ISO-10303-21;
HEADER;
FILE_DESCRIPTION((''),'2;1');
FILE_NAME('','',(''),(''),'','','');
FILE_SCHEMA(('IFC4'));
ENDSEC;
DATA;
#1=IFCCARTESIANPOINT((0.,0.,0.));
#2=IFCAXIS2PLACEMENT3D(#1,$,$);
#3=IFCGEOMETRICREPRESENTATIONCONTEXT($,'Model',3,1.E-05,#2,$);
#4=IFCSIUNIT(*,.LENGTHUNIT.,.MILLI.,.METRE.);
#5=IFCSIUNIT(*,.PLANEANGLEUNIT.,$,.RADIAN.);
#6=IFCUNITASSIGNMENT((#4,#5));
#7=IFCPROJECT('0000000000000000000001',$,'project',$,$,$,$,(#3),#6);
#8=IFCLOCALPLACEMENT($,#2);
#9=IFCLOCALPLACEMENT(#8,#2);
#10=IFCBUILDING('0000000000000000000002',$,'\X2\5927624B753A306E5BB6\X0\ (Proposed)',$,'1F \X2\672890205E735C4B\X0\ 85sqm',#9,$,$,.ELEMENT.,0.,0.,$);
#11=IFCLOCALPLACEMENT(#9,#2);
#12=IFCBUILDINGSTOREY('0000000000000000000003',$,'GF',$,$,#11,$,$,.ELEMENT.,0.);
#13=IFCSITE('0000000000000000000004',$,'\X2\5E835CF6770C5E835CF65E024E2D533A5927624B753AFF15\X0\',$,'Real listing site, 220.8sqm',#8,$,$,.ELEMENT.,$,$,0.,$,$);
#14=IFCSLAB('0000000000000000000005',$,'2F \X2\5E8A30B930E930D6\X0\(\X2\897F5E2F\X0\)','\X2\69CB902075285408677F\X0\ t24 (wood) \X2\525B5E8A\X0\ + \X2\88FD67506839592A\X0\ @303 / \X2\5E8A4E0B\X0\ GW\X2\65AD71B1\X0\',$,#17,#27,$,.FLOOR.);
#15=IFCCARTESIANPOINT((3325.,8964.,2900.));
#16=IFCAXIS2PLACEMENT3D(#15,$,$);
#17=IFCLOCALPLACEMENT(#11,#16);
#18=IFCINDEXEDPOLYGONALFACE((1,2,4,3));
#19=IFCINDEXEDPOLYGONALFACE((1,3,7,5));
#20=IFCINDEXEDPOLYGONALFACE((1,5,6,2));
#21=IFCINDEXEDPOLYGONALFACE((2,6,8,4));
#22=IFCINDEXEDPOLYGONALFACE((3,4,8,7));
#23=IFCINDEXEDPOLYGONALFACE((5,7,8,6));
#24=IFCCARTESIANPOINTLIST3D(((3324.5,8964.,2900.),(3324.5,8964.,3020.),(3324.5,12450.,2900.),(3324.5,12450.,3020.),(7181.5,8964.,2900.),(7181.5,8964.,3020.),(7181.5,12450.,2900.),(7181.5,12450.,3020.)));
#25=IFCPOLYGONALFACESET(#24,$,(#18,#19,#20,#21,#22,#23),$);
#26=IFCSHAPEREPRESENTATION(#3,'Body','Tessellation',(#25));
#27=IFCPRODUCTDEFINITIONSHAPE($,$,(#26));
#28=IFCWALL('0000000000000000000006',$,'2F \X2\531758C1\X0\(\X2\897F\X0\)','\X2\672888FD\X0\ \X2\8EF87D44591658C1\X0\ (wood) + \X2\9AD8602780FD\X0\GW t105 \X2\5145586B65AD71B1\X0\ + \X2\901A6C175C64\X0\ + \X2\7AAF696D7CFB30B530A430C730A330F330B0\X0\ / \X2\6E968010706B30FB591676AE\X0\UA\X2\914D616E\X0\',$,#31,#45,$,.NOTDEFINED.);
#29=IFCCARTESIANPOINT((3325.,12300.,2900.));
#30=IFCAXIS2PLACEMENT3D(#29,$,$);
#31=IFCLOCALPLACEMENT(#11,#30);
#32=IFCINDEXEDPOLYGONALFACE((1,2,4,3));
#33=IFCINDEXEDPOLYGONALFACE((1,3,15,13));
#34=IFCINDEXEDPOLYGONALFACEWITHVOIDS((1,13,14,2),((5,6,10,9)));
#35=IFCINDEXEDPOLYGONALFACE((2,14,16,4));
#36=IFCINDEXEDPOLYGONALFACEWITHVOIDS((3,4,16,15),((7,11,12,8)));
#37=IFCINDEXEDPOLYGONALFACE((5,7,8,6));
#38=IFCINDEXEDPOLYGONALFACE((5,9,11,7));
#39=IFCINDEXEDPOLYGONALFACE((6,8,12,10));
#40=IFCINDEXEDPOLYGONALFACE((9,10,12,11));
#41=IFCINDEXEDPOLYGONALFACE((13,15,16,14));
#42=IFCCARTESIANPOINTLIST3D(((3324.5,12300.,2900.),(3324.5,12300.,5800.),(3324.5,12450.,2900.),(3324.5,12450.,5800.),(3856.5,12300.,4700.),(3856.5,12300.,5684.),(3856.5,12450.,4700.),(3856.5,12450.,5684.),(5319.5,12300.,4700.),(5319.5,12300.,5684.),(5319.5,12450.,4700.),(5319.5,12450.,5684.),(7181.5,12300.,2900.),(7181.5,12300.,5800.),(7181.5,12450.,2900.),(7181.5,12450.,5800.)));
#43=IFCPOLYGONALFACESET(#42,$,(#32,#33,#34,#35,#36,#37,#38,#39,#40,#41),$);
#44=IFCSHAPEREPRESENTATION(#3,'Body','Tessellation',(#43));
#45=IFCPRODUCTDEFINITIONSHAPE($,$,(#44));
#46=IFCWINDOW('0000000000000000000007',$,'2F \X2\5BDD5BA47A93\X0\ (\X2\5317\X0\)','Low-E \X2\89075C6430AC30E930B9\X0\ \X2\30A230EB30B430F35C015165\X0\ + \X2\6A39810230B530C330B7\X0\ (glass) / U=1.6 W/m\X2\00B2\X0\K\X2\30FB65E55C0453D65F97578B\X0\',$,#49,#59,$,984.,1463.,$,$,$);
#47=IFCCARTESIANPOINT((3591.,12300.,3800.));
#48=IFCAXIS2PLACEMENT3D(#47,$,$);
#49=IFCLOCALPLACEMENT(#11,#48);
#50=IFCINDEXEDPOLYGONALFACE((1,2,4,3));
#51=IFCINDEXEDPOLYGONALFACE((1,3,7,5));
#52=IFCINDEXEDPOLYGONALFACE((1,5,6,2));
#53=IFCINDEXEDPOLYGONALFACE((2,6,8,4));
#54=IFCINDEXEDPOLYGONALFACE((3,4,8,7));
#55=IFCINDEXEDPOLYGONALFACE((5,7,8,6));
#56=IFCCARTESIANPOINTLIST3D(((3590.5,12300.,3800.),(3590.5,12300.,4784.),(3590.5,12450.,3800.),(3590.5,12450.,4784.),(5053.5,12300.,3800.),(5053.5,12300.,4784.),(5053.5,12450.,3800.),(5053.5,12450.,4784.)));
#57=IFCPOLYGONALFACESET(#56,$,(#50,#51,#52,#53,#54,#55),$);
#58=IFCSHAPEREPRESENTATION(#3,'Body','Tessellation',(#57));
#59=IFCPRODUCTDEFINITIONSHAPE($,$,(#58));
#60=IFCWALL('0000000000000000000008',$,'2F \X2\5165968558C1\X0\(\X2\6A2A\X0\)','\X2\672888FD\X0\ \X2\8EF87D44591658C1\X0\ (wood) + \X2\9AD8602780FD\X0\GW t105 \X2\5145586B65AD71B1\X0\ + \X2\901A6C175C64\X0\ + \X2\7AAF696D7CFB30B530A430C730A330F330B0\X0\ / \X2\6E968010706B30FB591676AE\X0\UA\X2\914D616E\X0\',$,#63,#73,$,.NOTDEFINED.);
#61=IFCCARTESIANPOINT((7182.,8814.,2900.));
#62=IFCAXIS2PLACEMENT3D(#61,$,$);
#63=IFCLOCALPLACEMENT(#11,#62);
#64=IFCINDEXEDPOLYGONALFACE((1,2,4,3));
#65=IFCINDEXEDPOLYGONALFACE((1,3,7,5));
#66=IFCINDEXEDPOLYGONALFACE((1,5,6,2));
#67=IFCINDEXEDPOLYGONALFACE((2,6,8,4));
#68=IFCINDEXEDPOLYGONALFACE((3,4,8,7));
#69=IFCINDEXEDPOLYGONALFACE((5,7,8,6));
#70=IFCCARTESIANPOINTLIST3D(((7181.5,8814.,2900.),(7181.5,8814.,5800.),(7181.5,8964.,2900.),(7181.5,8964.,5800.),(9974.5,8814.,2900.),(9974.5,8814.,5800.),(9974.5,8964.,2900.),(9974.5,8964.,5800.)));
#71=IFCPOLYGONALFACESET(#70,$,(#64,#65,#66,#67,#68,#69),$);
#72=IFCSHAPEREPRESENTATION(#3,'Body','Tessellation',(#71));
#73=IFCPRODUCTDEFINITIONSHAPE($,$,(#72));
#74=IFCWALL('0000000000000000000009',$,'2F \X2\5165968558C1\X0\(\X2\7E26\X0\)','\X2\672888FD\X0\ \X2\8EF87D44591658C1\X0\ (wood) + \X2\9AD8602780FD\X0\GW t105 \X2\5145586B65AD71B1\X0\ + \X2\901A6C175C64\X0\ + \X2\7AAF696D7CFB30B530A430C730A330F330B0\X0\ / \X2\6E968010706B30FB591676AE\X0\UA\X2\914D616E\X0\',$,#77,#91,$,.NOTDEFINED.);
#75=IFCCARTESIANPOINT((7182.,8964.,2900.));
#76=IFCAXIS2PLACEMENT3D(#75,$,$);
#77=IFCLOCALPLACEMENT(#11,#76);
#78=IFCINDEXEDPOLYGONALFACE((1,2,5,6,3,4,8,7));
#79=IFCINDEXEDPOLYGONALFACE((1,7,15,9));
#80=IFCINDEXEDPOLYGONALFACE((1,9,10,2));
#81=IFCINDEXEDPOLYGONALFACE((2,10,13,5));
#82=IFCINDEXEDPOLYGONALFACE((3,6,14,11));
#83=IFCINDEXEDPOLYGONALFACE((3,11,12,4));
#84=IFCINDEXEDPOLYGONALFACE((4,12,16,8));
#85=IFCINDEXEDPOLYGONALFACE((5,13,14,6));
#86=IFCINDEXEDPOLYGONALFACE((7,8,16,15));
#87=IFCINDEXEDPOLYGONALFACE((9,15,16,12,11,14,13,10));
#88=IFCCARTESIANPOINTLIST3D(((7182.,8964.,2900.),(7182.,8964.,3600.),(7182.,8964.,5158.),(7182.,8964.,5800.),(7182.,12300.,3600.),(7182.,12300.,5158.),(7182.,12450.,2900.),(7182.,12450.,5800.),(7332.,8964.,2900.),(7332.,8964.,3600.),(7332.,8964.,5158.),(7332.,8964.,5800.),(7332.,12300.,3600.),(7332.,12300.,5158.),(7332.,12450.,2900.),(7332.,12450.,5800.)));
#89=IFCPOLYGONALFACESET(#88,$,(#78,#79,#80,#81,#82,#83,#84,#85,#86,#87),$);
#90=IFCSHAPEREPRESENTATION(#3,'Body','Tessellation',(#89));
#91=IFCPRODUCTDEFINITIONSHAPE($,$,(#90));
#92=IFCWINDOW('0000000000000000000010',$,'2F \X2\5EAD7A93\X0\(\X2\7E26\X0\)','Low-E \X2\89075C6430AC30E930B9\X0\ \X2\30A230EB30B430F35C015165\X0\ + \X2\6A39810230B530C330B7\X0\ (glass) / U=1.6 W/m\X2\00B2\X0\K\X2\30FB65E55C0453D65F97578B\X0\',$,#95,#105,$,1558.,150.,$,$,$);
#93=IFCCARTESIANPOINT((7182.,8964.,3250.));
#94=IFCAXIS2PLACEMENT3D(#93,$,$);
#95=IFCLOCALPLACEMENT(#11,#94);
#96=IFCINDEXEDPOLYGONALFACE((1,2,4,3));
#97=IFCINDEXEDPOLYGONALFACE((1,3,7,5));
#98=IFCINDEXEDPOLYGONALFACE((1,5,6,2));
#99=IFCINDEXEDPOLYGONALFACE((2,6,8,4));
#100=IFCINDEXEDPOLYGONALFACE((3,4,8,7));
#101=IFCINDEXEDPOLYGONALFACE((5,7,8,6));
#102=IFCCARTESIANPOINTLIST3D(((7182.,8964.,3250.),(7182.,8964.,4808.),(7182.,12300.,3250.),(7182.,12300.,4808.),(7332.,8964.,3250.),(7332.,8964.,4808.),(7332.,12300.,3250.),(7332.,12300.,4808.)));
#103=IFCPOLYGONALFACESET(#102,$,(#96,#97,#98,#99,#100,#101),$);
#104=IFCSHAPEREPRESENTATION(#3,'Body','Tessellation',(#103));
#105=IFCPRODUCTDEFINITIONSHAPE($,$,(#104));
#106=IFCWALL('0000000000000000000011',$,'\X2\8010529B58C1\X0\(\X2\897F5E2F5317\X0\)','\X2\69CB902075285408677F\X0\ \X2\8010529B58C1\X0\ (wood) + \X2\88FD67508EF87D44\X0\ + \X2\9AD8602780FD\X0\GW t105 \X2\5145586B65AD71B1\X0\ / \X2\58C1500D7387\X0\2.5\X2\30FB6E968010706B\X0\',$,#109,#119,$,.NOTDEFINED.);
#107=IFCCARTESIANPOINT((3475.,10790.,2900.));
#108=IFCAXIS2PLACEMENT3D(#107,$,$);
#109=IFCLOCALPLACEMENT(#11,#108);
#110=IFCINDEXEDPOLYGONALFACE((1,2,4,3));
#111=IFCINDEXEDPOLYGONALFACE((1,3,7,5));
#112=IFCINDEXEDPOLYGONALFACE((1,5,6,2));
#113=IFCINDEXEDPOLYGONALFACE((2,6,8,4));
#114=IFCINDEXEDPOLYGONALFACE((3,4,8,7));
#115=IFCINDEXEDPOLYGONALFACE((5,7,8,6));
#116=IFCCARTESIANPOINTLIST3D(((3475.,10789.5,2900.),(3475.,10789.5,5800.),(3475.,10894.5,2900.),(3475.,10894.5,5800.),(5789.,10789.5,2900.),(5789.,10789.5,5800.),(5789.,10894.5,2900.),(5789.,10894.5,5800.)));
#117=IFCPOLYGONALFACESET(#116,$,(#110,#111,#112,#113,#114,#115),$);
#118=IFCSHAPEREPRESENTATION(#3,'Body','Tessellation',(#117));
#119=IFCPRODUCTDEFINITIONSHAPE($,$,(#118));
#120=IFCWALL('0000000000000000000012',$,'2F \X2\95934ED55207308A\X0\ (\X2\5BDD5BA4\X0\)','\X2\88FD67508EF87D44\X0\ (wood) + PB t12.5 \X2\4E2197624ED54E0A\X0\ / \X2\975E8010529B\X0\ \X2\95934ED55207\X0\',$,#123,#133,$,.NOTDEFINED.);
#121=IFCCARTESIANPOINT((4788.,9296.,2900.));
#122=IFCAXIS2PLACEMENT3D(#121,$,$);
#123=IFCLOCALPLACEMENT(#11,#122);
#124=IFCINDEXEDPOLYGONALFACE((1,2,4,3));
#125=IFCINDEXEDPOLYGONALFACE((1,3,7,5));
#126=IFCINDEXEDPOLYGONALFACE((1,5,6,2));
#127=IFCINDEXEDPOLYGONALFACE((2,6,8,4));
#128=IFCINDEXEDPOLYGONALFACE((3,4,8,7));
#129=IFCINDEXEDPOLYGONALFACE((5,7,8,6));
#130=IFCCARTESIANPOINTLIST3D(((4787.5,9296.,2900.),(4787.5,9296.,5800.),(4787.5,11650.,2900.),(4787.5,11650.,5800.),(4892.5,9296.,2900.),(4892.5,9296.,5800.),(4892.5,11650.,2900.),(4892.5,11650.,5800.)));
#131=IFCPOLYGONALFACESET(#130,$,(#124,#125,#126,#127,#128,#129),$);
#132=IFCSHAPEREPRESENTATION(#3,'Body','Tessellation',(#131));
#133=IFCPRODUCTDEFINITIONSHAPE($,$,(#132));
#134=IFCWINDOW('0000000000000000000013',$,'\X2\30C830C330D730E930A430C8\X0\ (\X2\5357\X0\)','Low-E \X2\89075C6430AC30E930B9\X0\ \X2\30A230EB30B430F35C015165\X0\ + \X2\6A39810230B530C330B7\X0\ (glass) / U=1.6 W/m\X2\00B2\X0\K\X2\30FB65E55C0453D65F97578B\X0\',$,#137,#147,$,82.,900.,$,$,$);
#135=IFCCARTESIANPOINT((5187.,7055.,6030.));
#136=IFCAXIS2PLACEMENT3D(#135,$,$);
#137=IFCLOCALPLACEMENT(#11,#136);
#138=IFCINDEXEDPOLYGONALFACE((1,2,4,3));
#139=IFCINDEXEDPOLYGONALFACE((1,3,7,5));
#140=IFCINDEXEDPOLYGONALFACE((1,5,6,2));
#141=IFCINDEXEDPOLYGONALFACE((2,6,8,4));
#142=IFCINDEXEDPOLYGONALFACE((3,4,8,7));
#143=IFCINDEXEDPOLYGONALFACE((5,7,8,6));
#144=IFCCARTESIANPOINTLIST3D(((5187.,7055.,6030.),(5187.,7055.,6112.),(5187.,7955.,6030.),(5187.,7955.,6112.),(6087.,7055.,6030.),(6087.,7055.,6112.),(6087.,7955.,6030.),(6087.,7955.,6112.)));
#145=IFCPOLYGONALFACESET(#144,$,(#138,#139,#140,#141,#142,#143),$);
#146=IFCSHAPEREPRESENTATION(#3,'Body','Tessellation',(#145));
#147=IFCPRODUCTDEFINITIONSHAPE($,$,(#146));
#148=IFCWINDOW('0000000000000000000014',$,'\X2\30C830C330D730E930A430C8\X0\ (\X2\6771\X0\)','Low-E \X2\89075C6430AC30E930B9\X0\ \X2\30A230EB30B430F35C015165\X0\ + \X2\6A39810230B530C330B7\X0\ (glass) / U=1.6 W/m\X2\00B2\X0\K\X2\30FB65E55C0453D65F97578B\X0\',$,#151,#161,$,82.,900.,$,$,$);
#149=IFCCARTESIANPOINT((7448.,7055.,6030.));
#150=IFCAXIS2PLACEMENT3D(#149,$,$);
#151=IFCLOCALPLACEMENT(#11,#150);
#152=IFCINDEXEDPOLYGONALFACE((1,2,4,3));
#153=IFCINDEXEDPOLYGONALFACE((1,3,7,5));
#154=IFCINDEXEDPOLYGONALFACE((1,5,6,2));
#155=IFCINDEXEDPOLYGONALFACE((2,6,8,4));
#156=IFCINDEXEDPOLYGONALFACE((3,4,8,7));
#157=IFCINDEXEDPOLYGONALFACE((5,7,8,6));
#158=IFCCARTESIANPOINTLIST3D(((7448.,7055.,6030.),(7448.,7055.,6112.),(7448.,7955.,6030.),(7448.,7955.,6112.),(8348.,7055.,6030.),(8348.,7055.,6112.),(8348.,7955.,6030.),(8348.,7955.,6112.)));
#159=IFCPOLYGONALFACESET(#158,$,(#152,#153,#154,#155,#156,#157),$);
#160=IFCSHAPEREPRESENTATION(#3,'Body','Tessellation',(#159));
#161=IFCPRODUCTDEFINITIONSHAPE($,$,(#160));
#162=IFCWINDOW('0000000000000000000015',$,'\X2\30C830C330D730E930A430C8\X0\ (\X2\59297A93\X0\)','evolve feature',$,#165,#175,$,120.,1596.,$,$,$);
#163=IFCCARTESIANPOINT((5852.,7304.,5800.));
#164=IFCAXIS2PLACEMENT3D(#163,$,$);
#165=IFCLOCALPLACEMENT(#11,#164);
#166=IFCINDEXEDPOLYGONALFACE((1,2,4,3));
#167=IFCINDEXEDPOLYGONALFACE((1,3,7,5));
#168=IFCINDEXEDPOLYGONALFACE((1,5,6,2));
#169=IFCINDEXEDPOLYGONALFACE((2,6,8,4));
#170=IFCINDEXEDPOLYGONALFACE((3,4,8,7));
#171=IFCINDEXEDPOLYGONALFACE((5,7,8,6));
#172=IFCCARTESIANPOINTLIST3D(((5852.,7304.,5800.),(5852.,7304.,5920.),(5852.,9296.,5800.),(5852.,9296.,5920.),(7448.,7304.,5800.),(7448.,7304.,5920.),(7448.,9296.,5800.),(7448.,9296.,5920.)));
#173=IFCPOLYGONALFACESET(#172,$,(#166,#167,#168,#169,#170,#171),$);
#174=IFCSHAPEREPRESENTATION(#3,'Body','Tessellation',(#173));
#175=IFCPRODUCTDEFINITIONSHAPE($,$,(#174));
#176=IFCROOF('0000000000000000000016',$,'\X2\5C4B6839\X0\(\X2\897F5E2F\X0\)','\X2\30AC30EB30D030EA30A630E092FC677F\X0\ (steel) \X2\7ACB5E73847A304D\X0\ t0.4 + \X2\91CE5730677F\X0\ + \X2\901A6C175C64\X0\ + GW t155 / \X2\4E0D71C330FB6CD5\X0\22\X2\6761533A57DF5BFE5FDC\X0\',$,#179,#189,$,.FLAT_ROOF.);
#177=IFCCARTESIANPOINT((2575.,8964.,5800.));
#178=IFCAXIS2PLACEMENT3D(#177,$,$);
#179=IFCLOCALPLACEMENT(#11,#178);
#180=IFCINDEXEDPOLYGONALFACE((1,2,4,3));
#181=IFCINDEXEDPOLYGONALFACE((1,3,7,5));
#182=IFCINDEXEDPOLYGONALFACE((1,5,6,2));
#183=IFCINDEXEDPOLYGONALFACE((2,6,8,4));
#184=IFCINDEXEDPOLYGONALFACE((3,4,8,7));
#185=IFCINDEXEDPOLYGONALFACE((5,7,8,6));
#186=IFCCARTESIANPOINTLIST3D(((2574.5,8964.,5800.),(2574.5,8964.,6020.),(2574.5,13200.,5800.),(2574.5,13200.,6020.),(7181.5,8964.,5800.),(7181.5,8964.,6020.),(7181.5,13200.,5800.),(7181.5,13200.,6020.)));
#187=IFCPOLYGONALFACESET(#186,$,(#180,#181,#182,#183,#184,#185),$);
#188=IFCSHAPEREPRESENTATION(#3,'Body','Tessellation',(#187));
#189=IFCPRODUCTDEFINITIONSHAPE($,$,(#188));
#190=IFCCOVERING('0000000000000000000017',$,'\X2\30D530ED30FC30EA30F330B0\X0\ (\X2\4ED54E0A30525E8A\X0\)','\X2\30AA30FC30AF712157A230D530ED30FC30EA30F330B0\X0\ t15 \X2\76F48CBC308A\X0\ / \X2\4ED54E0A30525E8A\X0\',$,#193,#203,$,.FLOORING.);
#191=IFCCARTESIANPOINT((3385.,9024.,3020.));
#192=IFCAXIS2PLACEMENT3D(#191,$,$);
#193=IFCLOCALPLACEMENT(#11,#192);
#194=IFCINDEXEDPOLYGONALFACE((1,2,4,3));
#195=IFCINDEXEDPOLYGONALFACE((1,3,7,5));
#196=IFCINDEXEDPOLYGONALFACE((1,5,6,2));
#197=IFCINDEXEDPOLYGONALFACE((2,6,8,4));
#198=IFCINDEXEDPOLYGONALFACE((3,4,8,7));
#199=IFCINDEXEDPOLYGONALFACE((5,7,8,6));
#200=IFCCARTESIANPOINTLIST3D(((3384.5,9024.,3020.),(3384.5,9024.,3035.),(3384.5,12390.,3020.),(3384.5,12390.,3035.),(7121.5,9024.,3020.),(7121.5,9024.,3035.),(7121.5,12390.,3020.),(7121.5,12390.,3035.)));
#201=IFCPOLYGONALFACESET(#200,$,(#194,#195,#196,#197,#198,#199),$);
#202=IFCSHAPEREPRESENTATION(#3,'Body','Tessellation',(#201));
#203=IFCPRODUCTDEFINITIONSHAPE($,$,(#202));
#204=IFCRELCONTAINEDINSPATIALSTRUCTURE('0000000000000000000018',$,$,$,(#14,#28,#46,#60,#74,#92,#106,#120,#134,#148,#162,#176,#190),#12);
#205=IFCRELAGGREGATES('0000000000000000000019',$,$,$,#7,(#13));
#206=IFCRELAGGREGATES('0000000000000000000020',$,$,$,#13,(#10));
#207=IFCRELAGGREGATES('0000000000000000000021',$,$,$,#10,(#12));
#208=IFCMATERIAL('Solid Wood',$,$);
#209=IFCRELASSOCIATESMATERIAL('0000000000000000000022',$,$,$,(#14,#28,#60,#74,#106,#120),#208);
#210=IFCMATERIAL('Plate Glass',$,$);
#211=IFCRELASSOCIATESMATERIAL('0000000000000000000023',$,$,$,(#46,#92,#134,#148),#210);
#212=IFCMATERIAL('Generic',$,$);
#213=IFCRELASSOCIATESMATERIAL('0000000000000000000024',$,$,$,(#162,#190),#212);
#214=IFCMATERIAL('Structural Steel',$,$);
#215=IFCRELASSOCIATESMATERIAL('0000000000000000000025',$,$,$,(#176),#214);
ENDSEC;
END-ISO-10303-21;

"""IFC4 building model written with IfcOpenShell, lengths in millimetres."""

from ifc_helpers import new_model, si_unit, frame, frame_2d, origin, place, context, project, spatial, rectangle, extrude, material, element, fill, save


model = new_model("IFC4")

# Units and contexts
model_context = context("Model", 3, precision=1e-05, world=origin())
ifc_project = project(units=[si_unit("LENGTHUNIT", "METRE", prefix="MILLI"), si_unit("PLANEANGLEUNIT", "RADIAN")], contexts=[model_context])

# Site, building, storey
site_placement = place(None, origin())
site = spatial("IfcSite", under=ifc_project, at=site_placement, Name="広島県広島市中区大手町５", ObjectType="Real listing site, 220.8sqm", CompositionType="ELEMENT", RefElevation=0.0)
building_placement = place(site_placement, origin())
building = spatial("IfcBuilding", under=site, at=building_placement, Name="大手町の家 (Proposed)", ObjectType="1F 木造平屋 85sqm", CompositionType="ELEMENT", ElevationOfRefHeight=0.0, ElevationOfTerrain=0.0)
storey_placement = place(building_placement, origin())
storey = spatial("IfcBuildingStorey", under=building, at=storey_placement, Name="GF", CompositionType="ELEMENT", Elevation=0.0)

# Slab
ifc_material_1 = material(Name="Solid Wood")
slab_placement = place(storey_placement, frame((3325.0, 8964.0, 2900.0)))
element("IfcSlab", 1, at=slab_placement, inside=storey, material=ifc_material_1, Name="2F 床スラブ(西帯)", Description="構造用合板 t24 (wood) 剛床 + 製材根太 @303 / 床下 GW断熱", PredefinedType="FLOOR", context=model_context, shape_type="SweptSolid", body=[
    extrude(rectangle(XDim=3857.0, YDim=3486.0, at=frame_2d((1928.0, 1743.0))), frame((3325.0, 8964.0, 2900.0)), (0.0, 0.0, 1.0), 120.0),
])

# Wall, opening, window
wall_1_placement = place(storey_placement, frame((3325.0, 12300.0, 2900.0)))
wall_1 = element("IfcWall", 2, at=wall_1_placement, inside=storey, material=ifc_material_1, Name="2F 北壁(西)", Description="木製 軸組外壁 (wood) + 高性能GW t105 充填断熱 + 通気層 + 窯業系サイディング / 準耐火・外皮UA配慮", PredefinedType="NOTDEFINED", context=model_context, shape_type="SweptSolid", body=[
    extrude(rectangle(XDim=3857.0, YDim=150.0, at=frame_2d((1928.0, 75.0))), frame((3325.0, 12300.0, 2900.0)), (0.0, 0.0, 1.0), 2900.0),
])
opening_1_placement = place(storey_placement, frame((3591.0, 12300.0, 3800.0)))
opening_1 = element("IfcOpeningElement", 3, at=opening_1_placement, cuts=wall_1, PredefinedType="NOTDEFINED", context=model_context, shape_type="SweptSolid", body=[
    extrude(rectangle(XDim=1463.0, YDim=150.0, at=frame_2d((731.0, 75.0))), frame((3591.0, 12300.0, 3800.0)), (0.0, 0.0, 1.0), 984.0),
])
ifc_material_2 = material(Name="Plate Glass")
window_1_placement = place(storey_placement, frame((3591.0, 12300.0, 3800.0)))
window_1 = element("IfcWindow", 4, at=window_1_placement, inside=storey, material=ifc_material_2, Name="2F 寝室窓 (北)", Description="Low-E 複層ガラス アルゴン封入 + 樹脂サッシ (glass) / U=1.6 W/m²K・日射取得型", OverallHeight=984.0, OverallWidth=1463.0, context=model_context, shape_type="SweptSolid", body=[
    extrude(rectangle(XDim=1463.0, YDim=150.0, at=frame_2d((731.0, 75.0))), frame((3591.0, 12300.0, 3800.0)), (0.0, 0.0, 1.0), 984.0),
])
fill(opening_1, window_1)

# Wall
wall_2_placement = place(storey_placement, frame((7182.0, 8814.0, 2900.0)))
element("IfcWall", 5, at=wall_2_placement, inside=storey, material=ifc_material_1, Name="2F 入隅壁(横)", Description="木製 軸組外壁 (wood) + 高性能GW t105 充填断熱 + 通気層 + 窯業系サイディング / 準耐火・外皮UA配慮", PredefinedType="NOTDEFINED", context=model_context, shape_type="SweptSolid", body=[
    extrude(rectangle(XDim=2793.0, YDim=150.0, at=frame_2d((1396.0, 75.0))), frame((7182.0, 8814.0, 2900.0)), (0.0, 0.0, 1.0), 2900.0),
])

# Wall, opening, window
wall_3_placement = place(storey_placement, frame((7182.0, 8964.0, 2900.0)))
wall_3 = element("IfcWall", 6, at=wall_3_placement, inside=storey, material=ifc_material_1, Name="2F 入隅壁(縦)", Description="木製 軸組外壁 (wood) + 高性能GW t105 充填断熱 + 通気層 + 窯業系サイディング / 準耐火・外皮UA配慮", PredefinedType="NOTDEFINED", context=model_context, shape_type="SweptSolid", body=[
    extrude(rectangle(XDim=150.0, YDim=3486.0, at=frame_2d((75.0, 1743.0))), frame((7182.0, 8964.0, 2900.0)), (0.0, 0.0, 1.0), 2900.0),
])
opening_2_placement = place(storey_placement, frame((7182.0, 8964.0, 3250.0)))
opening_2 = element("IfcOpeningElement", 7, at=opening_2_placement, cuts=wall_3, PredefinedType="NOTDEFINED", context=model_context, shape_type="SweptSolid", body=[
    extrude(rectangle(XDim=150.0, YDim=3336.0, at=frame_2d((75.0, 1668.0))), frame((7182.0, 8964.0, 3250.0)), (0.0, 0.0, 1.0), 1558.0),
])
window_2_placement = place(storey_placement, frame((7182.0, 8964.0, 3250.0)))
window_2 = element("IfcWindow", 8, at=window_2_placement, inside=storey, material=ifc_material_2, Name="2F 庭窓(縦)", Description="Low-E 複層ガラス アルゴン封入 + 樹脂サッシ (glass) / U=1.6 W/m²K・日射取得型", OverallHeight=1558.0, OverallWidth=150.0, context=model_context, shape_type="SweptSolid", body=[
    extrude(rectangle(XDim=150.0, YDim=3336.0, at=frame_2d((75.0, 1668.0))), frame((7182.0, 8964.0, 3250.0)), (0.0, 0.0, 1.0), 1558.0),
])
fill(opening_2, window_2)

# Walls
wall_4_placement = place(storey_placement, frame((3475.0, 10790.0, 2900.0)))
element("IfcWall", 9, at=wall_4_placement, inside=storey, material=ifc_material_1, Name="耐力壁(西帯北)", Description="構造用合板 耐力壁 (wood) + 製材軸組 + 高性能GW t105 充填断熱 / 壁倍率2.5・準耐火", PredefinedType="NOTDEFINED", context=model_context, shape_type="SweptSolid", body=[
    extrude(rectangle(XDim=2314.0, YDim=105.0, at=frame_2d((1157.0, 52.0))), frame((3475.0, 10790.0, 2900.0)), (0.0, 0.0, 1.0), 2900.0),
])
wall_5_placement = place(storey_placement, frame((4788.0, 9296.0, 2900.0)))
element("IfcWall", 10, at=wall_5_placement, inside=storey, material=ifc_material_1, Name="2F 間仕切り (寝室)", Description="製材軸組 (wood) + PB t12.5 両面仕上 / 非耐力 間仕切", PredefinedType="NOTDEFINED", context=model_context, shape_type="SweptSolid", body=[
    extrude(rectangle(XDim=105.0, YDim=2354.0, at=frame_2d((52.0, 1177.0))), frame((4788.0, 9296.0, 2900.0)), (0.0, 0.0, 1.0), 2900.0),
])

# Windows
window_3_placement = place(storey_placement, frame((5187.0, 7055.0, 6030.0)))
element("IfcWindow", 11, at=window_3_placement, inside=storey, material=ifc_material_2, Name="トップライト (南)", Description="Low-E 複層ガラス アルゴン封入 + 樹脂サッシ (glass) / U=1.6 W/m²K・日射取得型", OverallHeight=82.0, OverallWidth=900.0, context=model_context, shape_type="SweptSolid", body=[
    extrude(rectangle(XDim=900.0, YDim=900.0, at=frame_2d((450.0, 450.0))), frame((5187.0, 7055.0, 6030.0)), (0.0, 0.0, 1.0), 82.0),
])
window_4_placement = place(storey_placement, frame((7448.0, 7055.0, 6030.0)))
element("IfcWindow", 12, at=window_4_placement, inside=storey, material=ifc_material_2, Name="トップライト (東)", Description="Low-E 複層ガラス アルゴン封入 + 樹脂サッシ (glass) / U=1.6 W/m²K・日射取得型", OverallHeight=82.0, OverallWidth=900.0, context=model_context, shape_type="SweptSolid", body=[
    extrude(rectangle(XDim=900.0, YDim=900.0, at=frame_2d((450.0, 450.0))), frame((7448.0, 7055.0, 6030.0)), (0.0, 0.0, 1.0), 82.0),
])
ifc_material_3 = material(Name="Generic")
window_5_placement = place(storey_placement, frame((5852.0, 7304.0, 5800.0)))
element("IfcWindow", 13, at=window_5_placement, inside=storey, material=ifc_material_3, Name="トップライト (天窓)", Description="evolve feature", OverallHeight=120.0, OverallWidth=1596.0, context=model_context, shape_type="SweptSolid", body=[
    extrude(rectangle(XDim=1596.0, YDim=1992.0, at=frame_2d((798.0, 996.0))), frame((5852.0, 7304.0, 5800.0)), (0.0, 0.0, 1.0), 120.0),
])

# Roof
ifc_material_4 = material(Name="Structural Steel")
for number, where, name in (
    (14, (2575.0, 8964.0, 5800.0), "屋根(西帯)"),
):
    element("IfcRoof", number, at=place(storey_placement, frame(where)), inside=storey, material=ifc_material_4, Name=name, Description="ガルバリウム鋼板 (steel) 立平葺き t0.4 + 野地板 + 通気層 + GW t155 / 不燃・法22条区域対応", PredefinedType="FLAT_ROOF", context=model_context, shape_type="SweptSolid", body=[
        extrude(rectangle(XDim=4607.0, YDim=4236.0, at=frame_2d((2303.0, 2118.0))), frame((2575.0, 8964.0, 5800.0)), (0.0, 0.0, 1.0), 220.0),
    ])

# Covering
covering_placement = place(storey_placement, frame((3385.0, 9024.0, 3020.0)))
element("IfcCovering", 15, at=covering_placement, inside=storey, material=ifc_material_3, Name="フローリング (仕上げ床)", Description="オーク無垢フローリング t15 直貼り / 仕上げ床", PredefinedType="FLOORING", context=model_context, shape_type="SweptSolid", body=[
    extrude(rectangle(XDim=3737.0, YDim=3366.0, at=frame_2d((1868.0, 1683.0))), frame((3385.0, 9024.0, 3020.0)), (0.0, 0.0, 1.0), 15.0),
])

save(model, "model.ifc")
